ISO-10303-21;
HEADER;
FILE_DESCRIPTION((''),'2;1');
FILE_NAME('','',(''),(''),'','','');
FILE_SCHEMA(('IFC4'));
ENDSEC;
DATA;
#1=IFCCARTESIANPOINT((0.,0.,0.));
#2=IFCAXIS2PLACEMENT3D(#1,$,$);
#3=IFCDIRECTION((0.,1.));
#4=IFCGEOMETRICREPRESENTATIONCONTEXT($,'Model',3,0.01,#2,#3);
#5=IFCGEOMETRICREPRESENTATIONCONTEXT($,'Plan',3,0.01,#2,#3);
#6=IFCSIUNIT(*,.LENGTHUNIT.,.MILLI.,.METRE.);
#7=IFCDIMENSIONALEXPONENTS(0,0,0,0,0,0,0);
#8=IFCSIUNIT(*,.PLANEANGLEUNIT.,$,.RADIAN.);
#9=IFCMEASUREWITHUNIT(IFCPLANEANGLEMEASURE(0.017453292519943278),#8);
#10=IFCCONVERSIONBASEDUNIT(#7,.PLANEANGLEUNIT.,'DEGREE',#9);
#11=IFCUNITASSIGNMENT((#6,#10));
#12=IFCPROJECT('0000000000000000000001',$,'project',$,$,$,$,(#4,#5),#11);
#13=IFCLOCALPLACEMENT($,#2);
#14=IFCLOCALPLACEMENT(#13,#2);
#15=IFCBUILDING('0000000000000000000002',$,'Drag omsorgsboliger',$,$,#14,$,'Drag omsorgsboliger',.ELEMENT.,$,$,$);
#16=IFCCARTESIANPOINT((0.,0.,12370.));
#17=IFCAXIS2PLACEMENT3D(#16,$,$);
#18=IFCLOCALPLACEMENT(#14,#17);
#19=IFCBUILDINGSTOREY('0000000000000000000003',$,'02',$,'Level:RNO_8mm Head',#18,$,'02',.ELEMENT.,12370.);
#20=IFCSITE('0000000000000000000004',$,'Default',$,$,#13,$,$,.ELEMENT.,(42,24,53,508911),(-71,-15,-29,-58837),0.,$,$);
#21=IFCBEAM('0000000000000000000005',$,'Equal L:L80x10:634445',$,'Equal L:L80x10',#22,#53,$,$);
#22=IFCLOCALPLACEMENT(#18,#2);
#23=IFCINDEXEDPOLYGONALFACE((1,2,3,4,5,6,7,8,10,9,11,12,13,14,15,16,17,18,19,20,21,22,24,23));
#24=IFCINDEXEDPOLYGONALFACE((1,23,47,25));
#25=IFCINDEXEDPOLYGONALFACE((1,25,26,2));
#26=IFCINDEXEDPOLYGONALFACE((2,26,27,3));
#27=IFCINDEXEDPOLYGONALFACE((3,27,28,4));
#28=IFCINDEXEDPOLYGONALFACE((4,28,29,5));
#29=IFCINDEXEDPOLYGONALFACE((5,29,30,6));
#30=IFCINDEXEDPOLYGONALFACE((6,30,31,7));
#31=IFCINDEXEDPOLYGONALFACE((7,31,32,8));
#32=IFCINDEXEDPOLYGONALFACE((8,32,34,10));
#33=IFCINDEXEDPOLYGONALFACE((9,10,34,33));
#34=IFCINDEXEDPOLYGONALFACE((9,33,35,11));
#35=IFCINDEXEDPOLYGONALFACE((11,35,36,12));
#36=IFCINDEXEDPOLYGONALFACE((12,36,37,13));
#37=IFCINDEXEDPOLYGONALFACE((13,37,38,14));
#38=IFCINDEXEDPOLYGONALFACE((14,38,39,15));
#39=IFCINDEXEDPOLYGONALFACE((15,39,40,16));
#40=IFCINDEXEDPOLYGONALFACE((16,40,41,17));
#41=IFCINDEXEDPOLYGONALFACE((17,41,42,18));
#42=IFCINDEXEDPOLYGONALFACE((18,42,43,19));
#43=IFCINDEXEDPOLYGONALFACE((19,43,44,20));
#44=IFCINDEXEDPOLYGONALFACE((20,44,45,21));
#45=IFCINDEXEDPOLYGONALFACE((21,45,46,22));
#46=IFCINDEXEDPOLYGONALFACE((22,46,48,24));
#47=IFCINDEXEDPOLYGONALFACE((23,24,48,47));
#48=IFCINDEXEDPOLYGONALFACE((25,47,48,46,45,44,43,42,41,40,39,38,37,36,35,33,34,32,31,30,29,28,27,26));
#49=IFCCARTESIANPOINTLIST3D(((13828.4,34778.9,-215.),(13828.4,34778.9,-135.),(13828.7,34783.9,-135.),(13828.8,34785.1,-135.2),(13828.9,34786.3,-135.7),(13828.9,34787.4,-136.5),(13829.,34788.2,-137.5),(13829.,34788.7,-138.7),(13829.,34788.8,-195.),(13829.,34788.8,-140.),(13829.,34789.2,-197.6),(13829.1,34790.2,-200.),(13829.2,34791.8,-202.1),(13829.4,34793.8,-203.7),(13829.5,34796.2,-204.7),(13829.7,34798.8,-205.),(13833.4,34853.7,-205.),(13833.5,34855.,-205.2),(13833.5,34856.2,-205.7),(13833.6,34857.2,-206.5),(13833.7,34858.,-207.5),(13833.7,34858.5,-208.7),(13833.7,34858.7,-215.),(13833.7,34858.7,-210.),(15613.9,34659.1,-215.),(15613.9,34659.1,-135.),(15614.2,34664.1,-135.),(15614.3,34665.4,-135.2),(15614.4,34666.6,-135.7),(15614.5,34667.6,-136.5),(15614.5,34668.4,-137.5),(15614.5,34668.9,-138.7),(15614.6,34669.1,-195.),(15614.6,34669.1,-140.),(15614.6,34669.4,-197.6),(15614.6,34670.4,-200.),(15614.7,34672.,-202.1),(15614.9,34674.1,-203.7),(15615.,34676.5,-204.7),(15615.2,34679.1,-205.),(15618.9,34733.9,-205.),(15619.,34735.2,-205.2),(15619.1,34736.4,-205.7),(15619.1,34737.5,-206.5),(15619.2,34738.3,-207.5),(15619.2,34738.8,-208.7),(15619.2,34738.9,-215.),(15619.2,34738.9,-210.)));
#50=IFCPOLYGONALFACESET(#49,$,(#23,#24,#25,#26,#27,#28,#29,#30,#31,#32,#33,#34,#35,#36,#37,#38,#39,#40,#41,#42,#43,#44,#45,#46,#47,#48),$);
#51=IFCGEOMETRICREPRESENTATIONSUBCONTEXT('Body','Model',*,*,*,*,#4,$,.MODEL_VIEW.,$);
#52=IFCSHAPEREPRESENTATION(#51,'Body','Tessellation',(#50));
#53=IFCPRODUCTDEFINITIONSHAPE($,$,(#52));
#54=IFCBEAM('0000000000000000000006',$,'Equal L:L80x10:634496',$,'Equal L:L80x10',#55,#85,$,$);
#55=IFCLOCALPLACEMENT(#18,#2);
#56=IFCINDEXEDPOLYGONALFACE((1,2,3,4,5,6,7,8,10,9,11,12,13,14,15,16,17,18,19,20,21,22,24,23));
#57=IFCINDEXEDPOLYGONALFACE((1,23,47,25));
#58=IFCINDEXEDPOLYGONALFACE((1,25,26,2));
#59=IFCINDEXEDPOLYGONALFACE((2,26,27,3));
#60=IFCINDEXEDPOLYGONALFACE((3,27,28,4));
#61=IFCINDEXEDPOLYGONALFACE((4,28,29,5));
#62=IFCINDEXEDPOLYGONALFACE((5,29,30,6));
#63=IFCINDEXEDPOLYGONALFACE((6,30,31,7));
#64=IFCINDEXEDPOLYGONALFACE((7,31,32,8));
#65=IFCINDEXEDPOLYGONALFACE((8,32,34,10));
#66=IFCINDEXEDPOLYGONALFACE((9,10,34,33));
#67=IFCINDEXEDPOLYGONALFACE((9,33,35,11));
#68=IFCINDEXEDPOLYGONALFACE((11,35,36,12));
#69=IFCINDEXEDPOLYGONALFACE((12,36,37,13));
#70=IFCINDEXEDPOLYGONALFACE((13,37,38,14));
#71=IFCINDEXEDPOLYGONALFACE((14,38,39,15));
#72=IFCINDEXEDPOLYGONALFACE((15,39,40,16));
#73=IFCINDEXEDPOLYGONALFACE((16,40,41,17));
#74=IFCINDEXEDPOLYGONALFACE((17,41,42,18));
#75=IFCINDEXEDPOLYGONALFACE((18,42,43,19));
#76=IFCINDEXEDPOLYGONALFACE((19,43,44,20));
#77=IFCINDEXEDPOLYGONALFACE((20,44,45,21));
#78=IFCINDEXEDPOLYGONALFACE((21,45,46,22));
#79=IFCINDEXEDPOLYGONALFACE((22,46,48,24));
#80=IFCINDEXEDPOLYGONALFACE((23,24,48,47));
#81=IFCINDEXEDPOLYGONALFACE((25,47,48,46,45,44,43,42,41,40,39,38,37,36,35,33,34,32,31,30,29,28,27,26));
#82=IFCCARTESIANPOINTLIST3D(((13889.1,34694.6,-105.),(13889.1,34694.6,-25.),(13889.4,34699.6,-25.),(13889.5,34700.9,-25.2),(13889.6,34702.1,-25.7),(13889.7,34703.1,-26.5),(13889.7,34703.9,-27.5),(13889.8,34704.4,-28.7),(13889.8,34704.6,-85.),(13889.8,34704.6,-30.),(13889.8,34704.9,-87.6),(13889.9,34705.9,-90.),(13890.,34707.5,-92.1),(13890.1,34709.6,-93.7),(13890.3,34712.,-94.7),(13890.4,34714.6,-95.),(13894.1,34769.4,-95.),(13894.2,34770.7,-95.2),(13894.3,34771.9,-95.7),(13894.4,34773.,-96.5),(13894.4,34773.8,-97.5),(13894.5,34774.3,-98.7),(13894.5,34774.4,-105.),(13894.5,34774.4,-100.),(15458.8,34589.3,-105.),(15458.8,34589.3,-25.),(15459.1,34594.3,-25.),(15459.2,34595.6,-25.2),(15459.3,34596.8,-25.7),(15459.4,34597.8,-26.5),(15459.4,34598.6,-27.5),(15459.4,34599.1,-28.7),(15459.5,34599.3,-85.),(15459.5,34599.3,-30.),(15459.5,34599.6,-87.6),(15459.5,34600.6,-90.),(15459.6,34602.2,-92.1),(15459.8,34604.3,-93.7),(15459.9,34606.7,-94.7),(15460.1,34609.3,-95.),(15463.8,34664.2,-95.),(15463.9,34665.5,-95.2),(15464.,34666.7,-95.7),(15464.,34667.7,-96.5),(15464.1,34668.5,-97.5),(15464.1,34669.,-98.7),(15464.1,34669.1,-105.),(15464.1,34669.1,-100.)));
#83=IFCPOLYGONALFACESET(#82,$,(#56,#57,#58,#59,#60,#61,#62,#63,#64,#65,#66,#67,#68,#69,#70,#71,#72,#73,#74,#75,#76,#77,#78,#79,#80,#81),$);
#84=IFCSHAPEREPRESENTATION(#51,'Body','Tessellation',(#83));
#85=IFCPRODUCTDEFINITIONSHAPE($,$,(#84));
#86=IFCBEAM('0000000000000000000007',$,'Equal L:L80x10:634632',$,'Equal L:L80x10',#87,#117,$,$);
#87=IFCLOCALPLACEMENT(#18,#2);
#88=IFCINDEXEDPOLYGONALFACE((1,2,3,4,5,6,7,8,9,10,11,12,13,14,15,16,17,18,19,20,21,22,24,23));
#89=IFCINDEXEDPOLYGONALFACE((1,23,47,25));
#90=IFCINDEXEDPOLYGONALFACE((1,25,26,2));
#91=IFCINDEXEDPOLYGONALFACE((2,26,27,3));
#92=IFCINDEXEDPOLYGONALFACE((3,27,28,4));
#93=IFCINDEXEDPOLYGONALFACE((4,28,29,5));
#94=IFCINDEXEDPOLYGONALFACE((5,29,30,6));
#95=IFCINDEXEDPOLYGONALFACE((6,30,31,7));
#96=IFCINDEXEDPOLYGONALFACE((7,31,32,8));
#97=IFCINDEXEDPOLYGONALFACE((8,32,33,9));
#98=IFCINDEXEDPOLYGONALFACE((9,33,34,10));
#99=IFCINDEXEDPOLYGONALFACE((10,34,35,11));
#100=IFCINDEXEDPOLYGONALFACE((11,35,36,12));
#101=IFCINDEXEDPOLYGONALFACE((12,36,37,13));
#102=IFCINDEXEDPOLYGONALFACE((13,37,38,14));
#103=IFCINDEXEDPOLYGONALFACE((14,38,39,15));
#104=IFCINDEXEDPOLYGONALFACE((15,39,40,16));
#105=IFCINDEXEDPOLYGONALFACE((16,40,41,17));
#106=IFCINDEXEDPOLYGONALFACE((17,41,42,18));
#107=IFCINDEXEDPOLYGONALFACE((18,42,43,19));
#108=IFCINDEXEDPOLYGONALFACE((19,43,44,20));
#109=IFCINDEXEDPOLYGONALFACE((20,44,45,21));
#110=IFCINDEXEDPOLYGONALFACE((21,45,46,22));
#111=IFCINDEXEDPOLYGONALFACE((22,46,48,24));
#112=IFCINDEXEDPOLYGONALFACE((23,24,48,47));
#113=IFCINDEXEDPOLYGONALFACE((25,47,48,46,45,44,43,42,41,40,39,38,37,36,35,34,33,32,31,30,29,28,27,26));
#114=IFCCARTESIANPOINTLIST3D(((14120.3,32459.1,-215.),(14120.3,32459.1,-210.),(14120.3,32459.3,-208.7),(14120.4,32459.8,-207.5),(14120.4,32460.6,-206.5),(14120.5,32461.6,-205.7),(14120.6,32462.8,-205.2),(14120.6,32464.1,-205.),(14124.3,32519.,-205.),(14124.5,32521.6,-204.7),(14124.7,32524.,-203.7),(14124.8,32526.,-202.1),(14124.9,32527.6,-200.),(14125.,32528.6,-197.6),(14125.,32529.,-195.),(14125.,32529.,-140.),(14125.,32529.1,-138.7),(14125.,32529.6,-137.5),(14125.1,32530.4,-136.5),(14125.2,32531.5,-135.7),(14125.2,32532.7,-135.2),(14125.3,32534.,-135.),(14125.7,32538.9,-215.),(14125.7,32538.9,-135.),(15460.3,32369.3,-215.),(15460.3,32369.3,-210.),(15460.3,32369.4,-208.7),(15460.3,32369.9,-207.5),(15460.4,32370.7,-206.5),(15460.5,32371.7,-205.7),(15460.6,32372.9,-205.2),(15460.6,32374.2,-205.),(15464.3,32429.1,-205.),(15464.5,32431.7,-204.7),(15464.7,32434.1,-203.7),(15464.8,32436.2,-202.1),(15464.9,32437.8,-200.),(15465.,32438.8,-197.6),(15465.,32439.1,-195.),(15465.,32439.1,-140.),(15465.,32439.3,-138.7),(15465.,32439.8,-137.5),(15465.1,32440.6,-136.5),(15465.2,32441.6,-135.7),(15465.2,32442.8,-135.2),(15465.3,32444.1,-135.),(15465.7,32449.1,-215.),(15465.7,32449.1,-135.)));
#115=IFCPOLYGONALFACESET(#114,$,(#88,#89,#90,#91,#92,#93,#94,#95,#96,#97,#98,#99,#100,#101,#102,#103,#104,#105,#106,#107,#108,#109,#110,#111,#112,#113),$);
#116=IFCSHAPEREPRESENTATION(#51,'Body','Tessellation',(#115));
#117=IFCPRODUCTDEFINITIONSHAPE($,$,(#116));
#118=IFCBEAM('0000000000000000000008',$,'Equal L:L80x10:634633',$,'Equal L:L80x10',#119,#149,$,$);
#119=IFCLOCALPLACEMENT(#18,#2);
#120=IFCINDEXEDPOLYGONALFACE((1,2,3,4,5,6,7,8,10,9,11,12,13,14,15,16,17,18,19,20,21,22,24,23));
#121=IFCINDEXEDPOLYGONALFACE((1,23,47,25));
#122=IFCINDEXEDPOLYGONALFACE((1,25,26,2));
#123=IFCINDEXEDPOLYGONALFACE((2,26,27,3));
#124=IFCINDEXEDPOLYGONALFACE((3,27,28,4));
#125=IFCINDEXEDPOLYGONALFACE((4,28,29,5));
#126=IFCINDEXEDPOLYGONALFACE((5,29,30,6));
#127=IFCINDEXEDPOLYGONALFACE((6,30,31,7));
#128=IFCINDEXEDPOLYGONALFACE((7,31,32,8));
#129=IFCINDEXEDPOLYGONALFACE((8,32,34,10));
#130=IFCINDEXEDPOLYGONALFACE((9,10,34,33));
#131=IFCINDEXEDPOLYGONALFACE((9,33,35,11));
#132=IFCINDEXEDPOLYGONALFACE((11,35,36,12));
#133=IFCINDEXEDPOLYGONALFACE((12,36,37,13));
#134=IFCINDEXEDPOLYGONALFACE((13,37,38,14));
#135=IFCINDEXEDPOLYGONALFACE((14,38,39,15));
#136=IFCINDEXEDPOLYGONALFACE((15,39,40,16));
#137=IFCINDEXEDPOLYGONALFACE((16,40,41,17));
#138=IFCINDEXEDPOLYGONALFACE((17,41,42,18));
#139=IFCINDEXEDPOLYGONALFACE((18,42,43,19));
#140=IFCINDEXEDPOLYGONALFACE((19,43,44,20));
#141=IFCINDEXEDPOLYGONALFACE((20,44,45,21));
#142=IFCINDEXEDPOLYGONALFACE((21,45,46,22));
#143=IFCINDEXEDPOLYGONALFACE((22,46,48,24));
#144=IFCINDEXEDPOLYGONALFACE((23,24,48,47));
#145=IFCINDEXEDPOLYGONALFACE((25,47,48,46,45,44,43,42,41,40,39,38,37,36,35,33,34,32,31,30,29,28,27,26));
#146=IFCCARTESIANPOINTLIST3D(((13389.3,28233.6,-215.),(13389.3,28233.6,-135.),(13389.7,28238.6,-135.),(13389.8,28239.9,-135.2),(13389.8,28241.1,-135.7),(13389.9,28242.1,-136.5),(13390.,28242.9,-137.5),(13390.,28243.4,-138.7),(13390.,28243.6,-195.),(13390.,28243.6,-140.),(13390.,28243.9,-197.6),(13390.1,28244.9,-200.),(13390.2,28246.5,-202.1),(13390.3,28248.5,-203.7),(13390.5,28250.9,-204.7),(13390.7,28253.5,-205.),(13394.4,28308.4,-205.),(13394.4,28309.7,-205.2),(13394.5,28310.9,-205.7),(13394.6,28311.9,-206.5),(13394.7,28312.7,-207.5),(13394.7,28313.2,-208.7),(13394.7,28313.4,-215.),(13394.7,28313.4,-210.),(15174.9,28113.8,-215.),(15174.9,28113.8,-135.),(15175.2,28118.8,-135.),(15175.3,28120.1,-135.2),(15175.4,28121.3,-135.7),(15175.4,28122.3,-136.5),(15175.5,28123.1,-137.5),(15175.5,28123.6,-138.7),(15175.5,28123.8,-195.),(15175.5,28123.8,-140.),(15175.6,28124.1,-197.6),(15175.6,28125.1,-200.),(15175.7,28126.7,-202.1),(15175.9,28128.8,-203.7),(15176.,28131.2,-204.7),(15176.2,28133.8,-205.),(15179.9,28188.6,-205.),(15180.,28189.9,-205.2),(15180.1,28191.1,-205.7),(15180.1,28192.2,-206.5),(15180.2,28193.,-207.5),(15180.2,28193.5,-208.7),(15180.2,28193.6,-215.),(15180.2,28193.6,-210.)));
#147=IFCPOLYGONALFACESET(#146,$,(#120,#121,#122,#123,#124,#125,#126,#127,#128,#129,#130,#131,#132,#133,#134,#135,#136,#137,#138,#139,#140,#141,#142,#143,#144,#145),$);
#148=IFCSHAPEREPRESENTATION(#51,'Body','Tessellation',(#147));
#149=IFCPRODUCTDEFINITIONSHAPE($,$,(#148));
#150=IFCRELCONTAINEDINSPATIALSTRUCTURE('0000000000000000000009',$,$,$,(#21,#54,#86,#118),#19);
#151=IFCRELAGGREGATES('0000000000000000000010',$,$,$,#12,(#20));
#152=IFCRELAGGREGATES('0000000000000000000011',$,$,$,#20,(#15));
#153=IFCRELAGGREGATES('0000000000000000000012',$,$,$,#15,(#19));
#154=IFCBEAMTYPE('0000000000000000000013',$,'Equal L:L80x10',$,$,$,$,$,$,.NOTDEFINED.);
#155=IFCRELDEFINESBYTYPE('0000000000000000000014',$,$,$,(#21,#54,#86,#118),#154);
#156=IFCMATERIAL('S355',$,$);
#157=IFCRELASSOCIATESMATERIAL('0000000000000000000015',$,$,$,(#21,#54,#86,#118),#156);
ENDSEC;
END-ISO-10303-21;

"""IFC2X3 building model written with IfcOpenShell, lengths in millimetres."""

from ifc_helpers import new_model, entity, si_unit, converted_unit, direction, frame, frame_2d, origin, place, context, subcontext, project, spatial, polyline, circle_curve, parameter, trimmed, segment, composite_curve, outline, extrude, material, type_object, element, save


model = new_model("IFC2X3")

# Units and contexts
model_context = context("Model", 3, precision=0.01, world=origin(), true_north=direction((0.0, 1.0)))
plan_context = context("Plan", 3, precision=0.01, world=origin(), true_north=direction((0.0, 1.0)))
body_context = subcontext(model_context, "Body", "Model", "MODEL_VIEW")
ifc_project = project(units=[si_unit("LENGTHUNIT", "METRE", prefix="MILLI"), converted_unit("PLANEANGLEUNIT", "DEGREE", entity("IfcPlaneAngleMeasure", 0.017453292519943278), si_unit("PLANEANGLEUNIT", "RADIAN"), dimensions=[0, 0, 0, 0, 0, 0, 0])], contexts=[model_context, plan_context])

# Site, building, storey
site_placement = place(None, origin())
site = spatial("IfcSite", under=ifc_project, at=site_placement, Name="Default", CompositionType="ELEMENT", RefLatitude=(42, 24, 53, 508911), RefLongitude=(-71, -15, -29, -58837), RefElevation=0.0)
building_placement = place(site_placement, origin())
building = spatial("IfcBuilding", under=site, at=building_placement, Name="Drag omsorgsboliger", LongName="Drag omsorgsboliger", CompositionType="ELEMENT")
storey_placement = place(building_placement, frame((0.0, 0.0, 12370.0)))
storey = spatial("IfcBuildingStorey", under=building, at=storey_placement, Name="02", ObjectType="Level:RNO_8mm Head", LongName="02", CompositionType="ELEMENT", Elevation=12370.0)

# Beams
ifc_material = material(Name="S355")
beam_type_1 = type_object("IfcBeamType", Name="Equal L:L80x10", PredefinedType="NOTDEFINED")
beam_1_placement = place(storey_placement, frame((15625.4, 34681.8, -135.0), z_axis=(0.0, 0.0, 1.0), x_axis=(-0.997758, 0.066923, 0.0)))
element("IfcBeam", 1, at=beam_1_placement, inside=storey, type_object=beam_type_1, material=ifc_material, Name="Equal L:L80x10:634445", ObjectType="Equal L:L80x10", context=body_context, shape_type="SweptSolid", body=[
    extrude(outline(composite_curve([segment(polyline([(26.1, -48.9), (31.1, -48.9)]), True, "CONTINUOUS"), segment(polyline([(31.1, -48.9), (31.1, 31.1)]), True, "CONTINUOUS"), segment(polyline([(31.1, 31.1), (-48.9, 31.1)]), True, "CONTINUOUS"), segment(polyline([(-48.9, 31.1), (-48.9, 26.1)]), True, "CONTINUOUS"), segment(trimmed(circle_curve(frame_2d((-43.9, 26.1), x_axis=(-1.0, 0.0)), 5.0), [parameter(0.0)], [parameter(90.0)], True, "PARAMETER"), True, "CONTINUOUS"), segment(polyline([(-43.9, 21.1), (11.1, 21.1)]), True, "CONTINUOUS"), segment(trimmed(circle_curve(frame_2d((11.1, 11.1), x_axis=(0.0, 1.0)), 10.0), [parameter(270.0)], [parameter(0.0)], True, "PARAMETER"), False, "CONTINUOUS"), segment(polyline([(21.1, 11.1), (21.1, -43.9)]), True, "CONTINUOUS"), segment(trimmed(circle_curve(frame_2d((26.1, -43.9), x_axis=(-1.0, 0.0)), 5.0), [parameter(0.0)], [parameter(90.0)], True, "PARAMETER"), True, "CONTINUOUS")], self_intersect=False)), frame((10.0, -7.7, -48.9), z_axis=(1.0, 0.0, 0.0), x_axis=(0.0, 0.0, -1.0)), (0.0, 0.0, 1.0), 1789.5),
])
beam_2_placement = place(storey_placement, frame((15620.1, 34602.0, -25.0), z_axis=(0.0, 0.0, 1.0), x_axis=(-0.997758, 0.066923, 0.0)))
element("IfcBeam", 2, at=beam_2_placement, inside=storey, type_object=beam_type_1, material=ifc_material, Name="Equal L:L80x10:634496", ObjectType="Equal L:L80x10", context=body_context, shape_type="SweptSolid", body=[
    extrude(outline(composite_curve([segment(polyline([(26.1, -48.9), (31.1, -48.9)]), True, "CONTINUOUS"), segment(polyline([(31.1, -48.9), (31.1, 31.1)]), True, "CONTINUOUS"), segment(polyline([(31.1, 31.1), (-48.9, 31.1)]), True, "CONTINUOUS"), segment(polyline([(-48.9, 31.1), (-48.9, 26.1)]), True, "CONTINUOUS"), segment(trimmed(circle_curve(frame_2d((-43.9, 26.1), x_axis=(-1.0, 0.0)), 5.0), [parameter(0.0)], [parameter(90.0)], True, "PARAMETER"), True, "CONTINUOUS"), segment(polyline([(-43.9, 21.1), (11.1, 21.1)]), True, "CONTINUOUS"), segment(trimmed(circle_curve(frame_2d((11.1, 11.1), x_axis=(0.0, 1.0)), 10.0), [parameter(270.0)], [parameter(0.0)], True, "PARAMETER"), False, "CONTINUOUS"), segment(polyline([(21.1, 11.1), (21.1, -43.9)]), True, "CONTINUOUS"), segment(trimmed(circle_curve(frame_2d((26.1, -43.9), x_axis=(-1.0, 0.0)), 5.0), [parameter(0.0)], [parameter(90.0)], True, "PARAMETER"), True, "CONTINUOUS")], self_intersect=False)), frame((160.1, -7.7, -48.9), z_axis=(1.0, 0.0, 0.0), x_axis=(0.0, 0.0, -1.0)), (0.0, 0.0, 1.0), 1573.2),
])
beam_3_placement = place(storey_placement, frame((15394.2, 32430.4, -135.0), z_axis=(0.0, 0.0, 1.0), x_axis=(-0.997758, 0.066923, 0.0)))
element("IfcBeam", 3, at=beam_3_placement, inside=storey, type_object=beam_type_1, material=ifc_material, Name="Equal L:L80x10:634632", ObjectType="Equal L:L80x10", context=body_context, shape_type="SweptSolid", body=[
    extrude(outline(composite_curve([segment(polyline([(-48.9, -31.1), (31.1, -31.1)]), True, "CONTINUOUS"), segment(polyline([(31.1, -31.1), (31.1, 48.9)]), True, "CONTINUOUS"), segment(polyline([(31.1, 48.9), (26.1, 48.9)]), True, "CONTINUOUS"), segment(trimmed(circle_curve(frame_2d((26.1, 43.9), x_axis=(0.0, 1.0)), 5.0), [parameter(0.0)], [parameter(90.0)], True, "PARAMETER"), True, "CONTINUOUS"), segment(polyline([(21.1, 43.9), (21.1, -11.1)]), True, "CONTINUOUS"), segment(trimmed(circle_curve(frame_2d((11.1, -11.1), x_axis=(1.0, 0.0)), 10.0), [parameter(270.0)], [parameter(0.0)], True, "PARAMETER"), False, "CONTINUOUS"), segment(polyline([(11.1, -21.1), (-43.9, -21.1)]), True, "CONTINUOUS"), segment(trimmed(circle_curve(frame_2d((-43.9, -26.1), x_axis=(0.0, 1.0)), 5.0), [parameter(0.0)], [parameter(90.0)], True, "PARAMETER"), True, "CONTINUOUS"), segment(polyline([(-48.9, -26.1), (-48.9, -31.1)]), True, "CONTINUOUS")], self_intersect=False)), frame((-70.0, 7.7, -48.9), z_axis=(1.0, 0.0, 0.0), x_axis=(0.0, 0.0, -1.0)), (0.0, 0.0, 1.0), 1343.0),
])
beam_4_placement = place(storey_placement, frame((15186.4, 28136.5, -135.0), z_axis=(0.0, 0.0, 1.0), x_axis=(-0.997758, 0.066923, 0.0)))
element("IfcBeam", 4, at=beam_4_placement, inside=storey, type_object=beam_type_1, material=ifc_material, Name="Equal L:L80x10:634633", ObjectType="Equal L:L80x10", context=body_context, shape_type="SweptSolid", body=[
    extrude(outline(composite_curve([segment(polyline([(26.1, -48.9), (31.1, -48.9)]), True, "CONTINUOUS"), segment(polyline([(31.1, -48.9), (31.1, 31.1)]), True, "CONTINUOUS"), segment(polyline([(31.1, 31.1), (-48.9, 31.1)]), True, "CONTINUOUS"), segment(polyline([(-48.9, 31.1), (-48.9, 26.1)]), True, "CONTINUOUS"), segment(trimmed(circle_curve(frame_2d((-43.9, 26.1), x_axis=(-1.0, 0.0)), 5.0), [parameter(0.0)], [parameter(90.0)], True, "PARAMETER"), True, "CONTINUOUS"), segment(polyline([(-43.9, 21.1), (11.1, 21.1)]), True, "CONTINUOUS"), segment(trimmed(circle_curve(frame_2d((11.1, 11.1), x_axis=(0.0, 1.0)), 10.0), [parameter(270.0)], [parameter(0.0)], True, "PARAMETER"), False, "CONTINUOUS"), segment(polyline([(21.1, 11.1), (21.1, -43.9)]), True, "CONTINUOUS"), segment(trimmed(circle_curve(frame_2d((26.1, -43.9), x_axis=(-1.0, 0.0)), 5.0), [parameter(0.0)], [parameter(90.0)], True, "PARAMETER"), True, "CONTINUOUS")], self_intersect=False)), frame((10.0, -7.7, -48.9), z_axis=(1.0, 0.0, 0.0), x_axis=(0.0, 0.0, -1.0)), (0.0, 0.0, 1.0), 1789.5),
])

save(model, "model.ifc")
